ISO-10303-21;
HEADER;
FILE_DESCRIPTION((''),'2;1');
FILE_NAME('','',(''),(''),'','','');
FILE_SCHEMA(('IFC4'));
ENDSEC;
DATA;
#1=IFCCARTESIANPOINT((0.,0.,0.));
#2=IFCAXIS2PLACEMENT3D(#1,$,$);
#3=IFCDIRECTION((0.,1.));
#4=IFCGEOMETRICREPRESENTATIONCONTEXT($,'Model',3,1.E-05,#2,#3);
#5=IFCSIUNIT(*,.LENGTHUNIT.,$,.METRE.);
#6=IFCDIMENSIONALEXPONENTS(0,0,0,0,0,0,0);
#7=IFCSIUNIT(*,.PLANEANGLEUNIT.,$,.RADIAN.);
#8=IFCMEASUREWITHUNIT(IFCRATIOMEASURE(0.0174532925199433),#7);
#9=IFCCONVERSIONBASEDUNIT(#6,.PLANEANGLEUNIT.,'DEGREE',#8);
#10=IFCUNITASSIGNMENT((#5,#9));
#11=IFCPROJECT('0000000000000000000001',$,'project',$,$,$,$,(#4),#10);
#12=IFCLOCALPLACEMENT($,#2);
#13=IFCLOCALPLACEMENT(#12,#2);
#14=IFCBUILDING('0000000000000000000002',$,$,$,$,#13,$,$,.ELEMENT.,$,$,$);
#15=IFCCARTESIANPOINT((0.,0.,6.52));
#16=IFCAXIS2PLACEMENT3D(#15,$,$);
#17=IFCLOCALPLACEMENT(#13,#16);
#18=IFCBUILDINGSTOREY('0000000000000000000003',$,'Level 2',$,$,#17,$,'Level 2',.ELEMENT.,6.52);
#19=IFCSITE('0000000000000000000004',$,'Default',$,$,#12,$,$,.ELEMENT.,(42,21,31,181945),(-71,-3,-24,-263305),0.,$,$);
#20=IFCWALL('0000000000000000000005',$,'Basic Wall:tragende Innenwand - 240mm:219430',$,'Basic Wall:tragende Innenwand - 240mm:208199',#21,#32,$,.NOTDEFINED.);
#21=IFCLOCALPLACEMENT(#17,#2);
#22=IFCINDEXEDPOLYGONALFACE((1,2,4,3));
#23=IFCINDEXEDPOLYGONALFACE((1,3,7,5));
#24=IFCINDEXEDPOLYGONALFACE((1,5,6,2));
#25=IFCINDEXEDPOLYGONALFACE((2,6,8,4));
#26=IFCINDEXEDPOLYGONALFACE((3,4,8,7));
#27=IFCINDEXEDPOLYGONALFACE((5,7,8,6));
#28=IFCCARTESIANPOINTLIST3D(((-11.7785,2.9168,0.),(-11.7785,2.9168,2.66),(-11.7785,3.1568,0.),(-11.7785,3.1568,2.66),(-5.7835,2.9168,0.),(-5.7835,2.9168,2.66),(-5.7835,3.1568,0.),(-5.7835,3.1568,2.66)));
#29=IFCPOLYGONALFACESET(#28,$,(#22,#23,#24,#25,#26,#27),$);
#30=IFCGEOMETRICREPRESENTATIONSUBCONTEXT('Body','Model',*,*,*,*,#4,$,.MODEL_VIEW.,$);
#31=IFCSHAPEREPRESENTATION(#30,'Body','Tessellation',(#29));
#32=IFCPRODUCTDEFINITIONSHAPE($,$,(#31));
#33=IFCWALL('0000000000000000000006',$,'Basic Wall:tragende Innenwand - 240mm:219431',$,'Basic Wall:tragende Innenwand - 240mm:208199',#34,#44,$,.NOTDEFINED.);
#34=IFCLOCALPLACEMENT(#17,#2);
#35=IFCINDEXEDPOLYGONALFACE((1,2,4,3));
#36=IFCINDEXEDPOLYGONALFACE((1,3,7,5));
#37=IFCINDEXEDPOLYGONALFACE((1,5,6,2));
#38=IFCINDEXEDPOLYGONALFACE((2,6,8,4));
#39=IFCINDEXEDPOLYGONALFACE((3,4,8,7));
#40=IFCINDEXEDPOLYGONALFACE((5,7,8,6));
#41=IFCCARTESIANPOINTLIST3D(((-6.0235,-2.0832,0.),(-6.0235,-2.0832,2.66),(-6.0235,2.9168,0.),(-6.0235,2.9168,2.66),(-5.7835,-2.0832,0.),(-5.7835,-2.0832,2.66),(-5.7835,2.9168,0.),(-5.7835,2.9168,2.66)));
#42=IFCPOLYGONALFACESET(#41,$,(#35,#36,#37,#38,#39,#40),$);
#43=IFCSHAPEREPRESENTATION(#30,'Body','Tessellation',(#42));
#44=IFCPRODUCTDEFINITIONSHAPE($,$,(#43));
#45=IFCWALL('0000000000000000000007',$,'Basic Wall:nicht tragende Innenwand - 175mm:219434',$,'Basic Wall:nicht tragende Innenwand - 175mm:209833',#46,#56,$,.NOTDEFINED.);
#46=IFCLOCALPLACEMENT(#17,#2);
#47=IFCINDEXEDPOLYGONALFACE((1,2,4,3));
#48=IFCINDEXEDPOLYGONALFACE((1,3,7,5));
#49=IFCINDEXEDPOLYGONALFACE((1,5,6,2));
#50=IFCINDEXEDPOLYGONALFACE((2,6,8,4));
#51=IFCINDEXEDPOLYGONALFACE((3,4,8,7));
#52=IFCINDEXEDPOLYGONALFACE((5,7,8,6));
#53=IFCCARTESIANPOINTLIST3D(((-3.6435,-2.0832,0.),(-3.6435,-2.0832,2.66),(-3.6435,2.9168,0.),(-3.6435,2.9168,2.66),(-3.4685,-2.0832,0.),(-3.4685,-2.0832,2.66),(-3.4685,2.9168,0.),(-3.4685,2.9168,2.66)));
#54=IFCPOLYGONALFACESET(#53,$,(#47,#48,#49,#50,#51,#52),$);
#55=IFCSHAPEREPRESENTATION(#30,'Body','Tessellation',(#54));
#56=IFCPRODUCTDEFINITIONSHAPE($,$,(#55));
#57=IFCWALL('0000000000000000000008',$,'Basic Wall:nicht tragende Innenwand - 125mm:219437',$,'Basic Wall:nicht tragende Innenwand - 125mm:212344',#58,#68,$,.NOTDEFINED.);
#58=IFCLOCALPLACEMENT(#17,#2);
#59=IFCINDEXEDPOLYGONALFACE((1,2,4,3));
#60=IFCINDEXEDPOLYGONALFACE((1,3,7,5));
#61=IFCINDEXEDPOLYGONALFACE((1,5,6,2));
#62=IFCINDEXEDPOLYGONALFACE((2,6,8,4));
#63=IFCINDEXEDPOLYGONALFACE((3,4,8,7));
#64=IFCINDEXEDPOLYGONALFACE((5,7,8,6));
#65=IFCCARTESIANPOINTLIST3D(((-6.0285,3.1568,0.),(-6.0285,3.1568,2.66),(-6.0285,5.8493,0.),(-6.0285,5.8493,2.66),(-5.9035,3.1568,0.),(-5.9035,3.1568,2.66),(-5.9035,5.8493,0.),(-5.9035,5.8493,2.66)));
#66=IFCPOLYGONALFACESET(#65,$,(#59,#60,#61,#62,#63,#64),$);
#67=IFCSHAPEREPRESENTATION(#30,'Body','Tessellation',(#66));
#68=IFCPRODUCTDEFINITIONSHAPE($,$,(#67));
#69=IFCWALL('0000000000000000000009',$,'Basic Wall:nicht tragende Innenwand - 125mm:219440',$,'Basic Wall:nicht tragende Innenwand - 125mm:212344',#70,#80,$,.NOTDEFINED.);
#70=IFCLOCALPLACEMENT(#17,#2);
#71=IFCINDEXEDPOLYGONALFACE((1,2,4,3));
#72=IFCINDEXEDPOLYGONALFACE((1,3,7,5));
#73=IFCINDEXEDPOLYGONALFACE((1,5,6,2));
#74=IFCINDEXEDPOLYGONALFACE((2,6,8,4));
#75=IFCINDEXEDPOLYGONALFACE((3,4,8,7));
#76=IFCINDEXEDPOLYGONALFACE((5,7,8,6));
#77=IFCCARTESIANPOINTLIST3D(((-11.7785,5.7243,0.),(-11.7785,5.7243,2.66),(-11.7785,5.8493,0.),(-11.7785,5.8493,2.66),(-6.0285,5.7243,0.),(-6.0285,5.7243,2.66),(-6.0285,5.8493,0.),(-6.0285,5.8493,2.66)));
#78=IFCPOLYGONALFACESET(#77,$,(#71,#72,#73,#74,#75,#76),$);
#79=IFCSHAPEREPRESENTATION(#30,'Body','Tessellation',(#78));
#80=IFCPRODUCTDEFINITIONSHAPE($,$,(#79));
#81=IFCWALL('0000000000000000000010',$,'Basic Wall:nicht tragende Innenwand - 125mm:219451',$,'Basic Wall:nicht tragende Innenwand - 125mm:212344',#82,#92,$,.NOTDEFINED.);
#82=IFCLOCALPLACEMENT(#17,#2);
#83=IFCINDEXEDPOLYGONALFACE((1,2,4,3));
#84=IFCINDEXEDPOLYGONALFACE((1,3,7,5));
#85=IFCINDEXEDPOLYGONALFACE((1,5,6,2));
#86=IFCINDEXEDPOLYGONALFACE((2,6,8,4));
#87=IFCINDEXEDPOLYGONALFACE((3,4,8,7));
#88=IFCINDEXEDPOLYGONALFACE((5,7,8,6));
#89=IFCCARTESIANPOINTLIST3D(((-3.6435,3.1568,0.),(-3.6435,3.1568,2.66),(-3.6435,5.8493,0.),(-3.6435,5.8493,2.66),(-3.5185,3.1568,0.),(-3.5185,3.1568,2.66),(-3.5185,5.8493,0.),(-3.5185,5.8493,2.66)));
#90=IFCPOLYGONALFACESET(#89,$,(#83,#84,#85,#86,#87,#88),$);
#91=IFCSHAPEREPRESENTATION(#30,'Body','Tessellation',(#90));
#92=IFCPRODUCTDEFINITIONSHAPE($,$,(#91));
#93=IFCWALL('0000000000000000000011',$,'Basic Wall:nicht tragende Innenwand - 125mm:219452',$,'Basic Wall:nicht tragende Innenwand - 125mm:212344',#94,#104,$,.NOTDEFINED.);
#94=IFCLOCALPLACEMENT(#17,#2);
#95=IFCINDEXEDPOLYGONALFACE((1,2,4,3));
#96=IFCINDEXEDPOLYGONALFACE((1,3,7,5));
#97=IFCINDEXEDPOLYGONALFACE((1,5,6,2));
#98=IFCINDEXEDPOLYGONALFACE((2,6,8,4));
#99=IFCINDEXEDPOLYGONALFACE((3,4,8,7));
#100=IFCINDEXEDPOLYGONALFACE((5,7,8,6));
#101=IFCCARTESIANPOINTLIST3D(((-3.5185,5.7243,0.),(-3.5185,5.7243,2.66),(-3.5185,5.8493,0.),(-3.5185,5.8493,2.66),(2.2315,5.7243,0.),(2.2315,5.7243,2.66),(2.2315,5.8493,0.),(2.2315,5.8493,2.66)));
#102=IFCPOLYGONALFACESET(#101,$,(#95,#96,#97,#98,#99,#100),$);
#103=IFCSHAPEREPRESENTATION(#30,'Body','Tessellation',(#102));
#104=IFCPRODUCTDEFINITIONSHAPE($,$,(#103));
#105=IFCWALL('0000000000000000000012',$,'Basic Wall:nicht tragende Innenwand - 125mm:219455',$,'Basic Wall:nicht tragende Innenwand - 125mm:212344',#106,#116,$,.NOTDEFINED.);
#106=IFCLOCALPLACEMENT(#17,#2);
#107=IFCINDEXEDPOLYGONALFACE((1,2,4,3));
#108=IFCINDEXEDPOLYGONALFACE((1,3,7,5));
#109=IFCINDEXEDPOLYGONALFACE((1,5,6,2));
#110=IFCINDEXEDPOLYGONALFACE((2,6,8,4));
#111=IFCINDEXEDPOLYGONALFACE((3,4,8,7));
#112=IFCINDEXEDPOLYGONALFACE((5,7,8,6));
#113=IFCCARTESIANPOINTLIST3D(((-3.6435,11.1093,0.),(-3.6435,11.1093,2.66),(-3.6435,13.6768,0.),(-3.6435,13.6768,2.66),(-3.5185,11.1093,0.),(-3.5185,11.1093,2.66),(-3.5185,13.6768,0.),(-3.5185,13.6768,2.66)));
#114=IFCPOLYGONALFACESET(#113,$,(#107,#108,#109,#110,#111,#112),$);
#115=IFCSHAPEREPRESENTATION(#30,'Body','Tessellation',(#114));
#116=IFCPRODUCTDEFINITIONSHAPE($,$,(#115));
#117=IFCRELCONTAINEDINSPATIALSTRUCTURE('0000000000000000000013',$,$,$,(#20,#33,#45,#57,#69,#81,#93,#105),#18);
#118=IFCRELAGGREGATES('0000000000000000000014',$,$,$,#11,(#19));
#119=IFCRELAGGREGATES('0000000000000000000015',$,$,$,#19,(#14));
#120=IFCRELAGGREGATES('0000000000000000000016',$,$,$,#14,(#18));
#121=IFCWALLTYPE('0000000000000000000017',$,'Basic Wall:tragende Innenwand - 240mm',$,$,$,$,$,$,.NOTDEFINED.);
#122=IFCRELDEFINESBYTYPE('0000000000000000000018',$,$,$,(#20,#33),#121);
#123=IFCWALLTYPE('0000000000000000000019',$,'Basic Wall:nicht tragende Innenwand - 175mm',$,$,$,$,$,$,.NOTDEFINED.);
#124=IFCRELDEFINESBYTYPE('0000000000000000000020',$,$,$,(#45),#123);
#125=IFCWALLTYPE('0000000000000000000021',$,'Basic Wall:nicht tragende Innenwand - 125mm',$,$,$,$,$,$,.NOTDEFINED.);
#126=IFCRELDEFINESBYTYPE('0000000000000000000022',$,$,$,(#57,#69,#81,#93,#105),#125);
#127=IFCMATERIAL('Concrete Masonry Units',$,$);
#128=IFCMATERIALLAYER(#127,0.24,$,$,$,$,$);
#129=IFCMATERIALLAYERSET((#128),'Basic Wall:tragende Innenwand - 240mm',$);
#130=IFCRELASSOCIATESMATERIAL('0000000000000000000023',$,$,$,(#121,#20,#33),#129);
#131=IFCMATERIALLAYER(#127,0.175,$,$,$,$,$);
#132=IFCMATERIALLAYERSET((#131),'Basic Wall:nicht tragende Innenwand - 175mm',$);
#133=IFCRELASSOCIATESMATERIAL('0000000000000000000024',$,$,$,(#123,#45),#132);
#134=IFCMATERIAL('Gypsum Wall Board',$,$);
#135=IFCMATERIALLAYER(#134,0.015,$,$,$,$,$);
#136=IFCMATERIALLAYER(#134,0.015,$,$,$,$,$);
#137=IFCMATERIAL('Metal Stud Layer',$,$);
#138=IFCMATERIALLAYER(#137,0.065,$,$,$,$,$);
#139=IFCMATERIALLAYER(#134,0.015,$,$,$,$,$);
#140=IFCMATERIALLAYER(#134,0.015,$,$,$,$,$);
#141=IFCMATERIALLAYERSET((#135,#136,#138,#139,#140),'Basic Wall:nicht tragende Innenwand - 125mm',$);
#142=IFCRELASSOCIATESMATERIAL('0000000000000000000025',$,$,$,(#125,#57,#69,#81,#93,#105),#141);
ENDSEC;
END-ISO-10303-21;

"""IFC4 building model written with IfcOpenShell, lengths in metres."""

from ifc_helpers import new_model, entity, si_unit, converted_unit, direction, frame, frame_2d, origin, place, context, subcontext, project, spatial, rectangle, extrude, material, layer, layer_set, layer_usage, type_object, element, save


model = new_model("IFC4")

# Units and contexts
model_context = context("Model", 3, precision=1e-05, world=origin(), true_north=direction((0.0, 1.0)))
body_context = subcontext(model_context, "Body", "Model", "MODEL_VIEW")
ifc_project = project(units=[si_unit("LENGTHUNIT", "METRE"), converted_unit("PLANEANGLEUNIT", "DEGREE", entity("IfcRatioMeasure", 0.0174532925199433), si_unit("PLANEANGLEUNIT", "RADIAN"), dimensions=[0, 0, 0, 0, 0, 0, 0])], contexts=[model_context])

# Site, building, storey
site_placement = place(None, origin())
site = spatial("IfcSite", under=ifc_project, at=site_placement, Name="Default", CompositionType="ELEMENT", RefLatitude=(42, 21, 31, 181945), RefLongitude=(-71, -3, -24, -263305), RefElevation=0.0)
building_placement = place(site_placement, origin())
building = spatial("IfcBuilding", under=site, at=building_placement, CompositionType="ELEMENT")
storey_placement = place(building_placement, frame((0.0, 0.0, 6.52)))
storey = spatial("IfcBuildingStorey", under=building, at=storey_placement, Name="Level 2", LongName="Level 2", CompositionType="ELEMENT", Elevation=6.52)

# Walls
ifc_material_1 = material(Name="Concrete Masonry Units")
ifc_layer_1 = layer(ifc_material_1, 0.24)
ifc_layer_set_1 = layer_set([ifc_layer_1], Name="Basic Wall:tragende Innenwand - 240mm")
ifc_layer_usage_1 = layer_usage(ifc_layer_set_1, "AXIS2", "NEGATIVE", 0.12)
wall_type_1 = type_object("IfcWallType", Name="Basic Wall:tragende Innenwand - 240mm", PredefinedType="NOTDEFINED", material=ifc_layer_set_1)
wall_1_placement = place(storey_placement, frame((-11.7785, 3.0368, 0.0)))
element("IfcWall", 1, at=wall_1_placement, inside=storey, type_object=wall_type_1, material=ifc_layer_usage_1, Name="Basic Wall:tragende Innenwand - 240mm:219430", ObjectType="Basic Wall:tragende Innenwand - 240mm:208199", PredefinedType="NOTDEFINED", context=body_context, shape_type="SweptSolid", body=[
    extrude(rectangle(XDim=5.995, YDim=0.24, at=frame_2d((2.9975, 0.0), x_axis=(-1.0, 0.0))), origin(), (0.0, 0.0, 1.0), 2.66),
])
ifc_layer_usage_2 = layer_usage(ifc_layer_set_1, "AXIS2", "NEGATIVE", 0.12)
wall_2_placement = place(storey_placement, frame((-5.9035, 2.9168, 0.0), z_axis=(0.0, 0.0, 1.0), x_axis=(0.0, -1.0, 0.0)))
element("IfcWall", 2, at=wall_2_placement, inside=storey, type_object=wall_type_1, material=ifc_layer_usage_2, Name="Basic Wall:tragende Innenwand - 240mm:219431", ObjectType="Basic Wall:tragende Innenwand - 240mm:208199", PredefinedType="NOTDEFINED", context=body_context, shape_type="SweptSolid", body=[
    extrude(rectangle(XDim=5.0, YDim=0.24, at=frame_2d((2.5, 0.0), x_axis=(-1.0, 0.0))), origin(), (0.0, 0.0, 1.0), 2.66),
])
ifc_layer_2 = layer(ifc_material_1, 0.175)
ifc_layer_set_2 = layer_set([ifc_layer_2], Name="Basic Wall:nicht tragende Innenwand - 175mm")
ifc_layer_usage_3 = layer_usage(ifc_layer_set_2, "AXIS2", "NEGATIVE", 0.0875)
wall_type_2 = type_object("IfcWallType", Name="Basic Wall:nicht tragende Innenwand - 175mm", PredefinedType="NOTDEFINED", material=ifc_layer_set_2)
wall_3_placement = place(storey_placement, frame((-3.556, 2.9168, 0.0), z_axis=(0.0, 0.0, 1.0), x_axis=(0.0, -1.0, 0.0)))
element("IfcWall", 3, at=wall_3_placement, inside=storey, type_object=wall_type_2, material=ifc_layer_usage_3, Name="Basic Wall:nicht tragende Innenwand - 175mm:219434", ObjectType="Basic Wall:nicht tragende Innenwand - 175mm:209833", PredefinedType="NOTDEFINED", context=body_context, shape_type="SweptSolid", body=[
    extrude(rectangle(XDim=5.0, YDim=0.175, at=frame_2d((2.5, 0.0), x_axis=(-1.0, 0.0))), origin(), (0.0, 0.0, 1.0), 2.66),
])
ifc_material_2 = material(Name="Gypsum Wall Board")
ifc_layer_3 = layer(ifc_material_2, 0.015)
ifc_layer_4 = layer(ifc_material_2, 0.015)
ifc_material_3 = material(Name="Metal Stud Layer")
ifc_layer_5 = layer(ifc_material_3, 0.065)
ifc_layer_6 = layer(ifc_material_2, 0.015)
ifc_layer_7 = layer(ifc_material_2, 0.015)
ifc_layer_set_3 = layer_set([ifc_layer_3, ifc_layer_4, ifc_layer_5, ifc_layer_6, ifc_layer_7], Name="Basic Wall:nicht tragende Innenwand - 125mm")
ifc_layer_usage_4 = layer_usage(ifc_layer_set_3, "AXIS2", "NEGATIVE", 0.0625)
wall_type_3 = type_object("IfcWallType", Name="Basic Wall:nicht tragende Innenwand - 125mm", PredefinedType="NOTDEFINED", material=ifc_layer_set_3)
wall_4_placement = place(storey_placement, frame((-5.966, 5.8493, 0.0), z_axis=(0.0, 0.0, 1.0), x_axis=(0.0, -1.0, 0.0)))
element("IfcWall", 4, at=wall_4_placement, inside=storey, type_object=wall_type_3, material=ifc_layer_usage_4, Name="Basic Wall:nicht tragende Innenwand - 125mm:219437", ObjectType="Basic Wall:nicht tragende Innenwand - 125mm:212344", PredefinedType="NOTDEFINED", context=body_context, shape_type="SweptSolid", body=[
    extrude(rectangle(XDim=2.6925, YDim=0.125, at=frame_2d((1.3462, 0.0), x_axis=(-1.0, 0.0))), origin(), (0.0, 0.0, 1.0), 2.66),
])
ifc_layer_usage_5 = layer_usage(ifc_layer_set_3, "AXIS2", "NEGATIVE", 0.0625)
wall_5_placement = place(storey_placement, frame((-6.0285, 5.7868, 0.0), z_axis=(0.0, 0.0, 1.0), x_axis=(-1.0, 0.0, 0.0)))
element("IfcWall", 5, at=wall_5_placement, inside=storey, type_object=wall_type_3, material=ifc_layer_usage_5, Name="Basic Wall:nicht tragende Innenwand - 125mm:219440", ObjectType="Basic Wall:nicht tragende Innenwand - 125mm:212344", PredefinedType="NOTDEFINED", context=body_context, shape_type="SweptSolid", body=[
    extrude(rectangle(XDim=5.75, YDim=0.125, at=frame_2d((2.875, 0.0), x_axis=(-1.0, 0.0))), origin(), (0.0, 0.0, 1.0), 2.66),
])
ifc_layer_usage_6 = layer_usage(ifc_layer_set_3, "AXIS2", "POSITIVE", -0.0625)
wall_6_placement = place(storey_placement, frame((-3.581, 5.8493, 0.0), z_axis=(0.0, 0.0, 1.0), x_axis=(0.0, -1.0, 0.0)))
element("IfcWall", 6, at=wall_6_placement, inside=storey, type_object=wall_type_3, material=ifc_layer_usage_6, Name="Basic Wall:nicht tragende Innenwand - 125mm:219451", ObjectType="Basic Wall:nicht tragende Innenwand - 125mm:212344", PredefinedType="NOTDEFINED", context=body_context, shape_type="SweptSolid", body=[
    extrude(rectangle(XDim=2.6925, YDim=0.125, at=frame_2d((1.3462, 0.0), x_axis=(-1.0, 0.0))), origin(), (0.0, 0.0, 1.0), 2.66),
])
ifc_layer_usage_7 = layer_usage(ifc_layer_set_3, "AXIS2", "POSITIVE", -0.0625)
wall_7_placement = place(storey_placement, frame((-3.5185, 5.7868, 0.0)))
element("IfcWall", 7, at=wall_7_placement, inside=storey, type_object=wall_type_3, material=ifc_layer_usage_7, Name="Basic Wall:nicht tragende Innenwand - 125mm:219452", ObjectType="Basic Wall:nicht tragende Innenwand - 125mm:212344", PredefinedType="NOTDEFINED", context=body_context, shape_type="SweptSolid", body=[
    extrude(rectangle(XDim=5.75, YDim=0.125, at=frame_2d((2.875, 0.0), x_axis=(-1.0, 0.0))), origin(), (0.0, 0.0, 1.0), 2.66),
])
ifc_layer_usage_8 = layer_usage(ifc_layer_set_3, "AXIS2", "NEGATIVE", 0.0625)
wall_8_placement = place(storey_placement, frame((-3.581, 11.1093, 0.0), z_axis=(0.0, 0.0, 1.0), x_axis=(0.0, 1.0, 0.0)))
element("IfcWall", 8, at=wall_8_placement, inside=storey, type_object=wall_type_3, material=ifc_layer_usage_8, Name="Basic Wall:nicht tragende Innenwand - 125mm:219455", ObjectType="Basic Wall:nicht tragende Innenwand - 125mm:212344", PredefinedType="NOTDEFINED", context=body_context, shape_type="SweptSolid", body=[
    extrude(rectangle(XDim=2.5675, YDim=0.125, at=frame_2d((1.2837, 0.0), x_axis=(-1.0, 0.0))), origin(), (0.0, 0.0, 1.0), 2.66),
])

save(model, "model.ifc")
